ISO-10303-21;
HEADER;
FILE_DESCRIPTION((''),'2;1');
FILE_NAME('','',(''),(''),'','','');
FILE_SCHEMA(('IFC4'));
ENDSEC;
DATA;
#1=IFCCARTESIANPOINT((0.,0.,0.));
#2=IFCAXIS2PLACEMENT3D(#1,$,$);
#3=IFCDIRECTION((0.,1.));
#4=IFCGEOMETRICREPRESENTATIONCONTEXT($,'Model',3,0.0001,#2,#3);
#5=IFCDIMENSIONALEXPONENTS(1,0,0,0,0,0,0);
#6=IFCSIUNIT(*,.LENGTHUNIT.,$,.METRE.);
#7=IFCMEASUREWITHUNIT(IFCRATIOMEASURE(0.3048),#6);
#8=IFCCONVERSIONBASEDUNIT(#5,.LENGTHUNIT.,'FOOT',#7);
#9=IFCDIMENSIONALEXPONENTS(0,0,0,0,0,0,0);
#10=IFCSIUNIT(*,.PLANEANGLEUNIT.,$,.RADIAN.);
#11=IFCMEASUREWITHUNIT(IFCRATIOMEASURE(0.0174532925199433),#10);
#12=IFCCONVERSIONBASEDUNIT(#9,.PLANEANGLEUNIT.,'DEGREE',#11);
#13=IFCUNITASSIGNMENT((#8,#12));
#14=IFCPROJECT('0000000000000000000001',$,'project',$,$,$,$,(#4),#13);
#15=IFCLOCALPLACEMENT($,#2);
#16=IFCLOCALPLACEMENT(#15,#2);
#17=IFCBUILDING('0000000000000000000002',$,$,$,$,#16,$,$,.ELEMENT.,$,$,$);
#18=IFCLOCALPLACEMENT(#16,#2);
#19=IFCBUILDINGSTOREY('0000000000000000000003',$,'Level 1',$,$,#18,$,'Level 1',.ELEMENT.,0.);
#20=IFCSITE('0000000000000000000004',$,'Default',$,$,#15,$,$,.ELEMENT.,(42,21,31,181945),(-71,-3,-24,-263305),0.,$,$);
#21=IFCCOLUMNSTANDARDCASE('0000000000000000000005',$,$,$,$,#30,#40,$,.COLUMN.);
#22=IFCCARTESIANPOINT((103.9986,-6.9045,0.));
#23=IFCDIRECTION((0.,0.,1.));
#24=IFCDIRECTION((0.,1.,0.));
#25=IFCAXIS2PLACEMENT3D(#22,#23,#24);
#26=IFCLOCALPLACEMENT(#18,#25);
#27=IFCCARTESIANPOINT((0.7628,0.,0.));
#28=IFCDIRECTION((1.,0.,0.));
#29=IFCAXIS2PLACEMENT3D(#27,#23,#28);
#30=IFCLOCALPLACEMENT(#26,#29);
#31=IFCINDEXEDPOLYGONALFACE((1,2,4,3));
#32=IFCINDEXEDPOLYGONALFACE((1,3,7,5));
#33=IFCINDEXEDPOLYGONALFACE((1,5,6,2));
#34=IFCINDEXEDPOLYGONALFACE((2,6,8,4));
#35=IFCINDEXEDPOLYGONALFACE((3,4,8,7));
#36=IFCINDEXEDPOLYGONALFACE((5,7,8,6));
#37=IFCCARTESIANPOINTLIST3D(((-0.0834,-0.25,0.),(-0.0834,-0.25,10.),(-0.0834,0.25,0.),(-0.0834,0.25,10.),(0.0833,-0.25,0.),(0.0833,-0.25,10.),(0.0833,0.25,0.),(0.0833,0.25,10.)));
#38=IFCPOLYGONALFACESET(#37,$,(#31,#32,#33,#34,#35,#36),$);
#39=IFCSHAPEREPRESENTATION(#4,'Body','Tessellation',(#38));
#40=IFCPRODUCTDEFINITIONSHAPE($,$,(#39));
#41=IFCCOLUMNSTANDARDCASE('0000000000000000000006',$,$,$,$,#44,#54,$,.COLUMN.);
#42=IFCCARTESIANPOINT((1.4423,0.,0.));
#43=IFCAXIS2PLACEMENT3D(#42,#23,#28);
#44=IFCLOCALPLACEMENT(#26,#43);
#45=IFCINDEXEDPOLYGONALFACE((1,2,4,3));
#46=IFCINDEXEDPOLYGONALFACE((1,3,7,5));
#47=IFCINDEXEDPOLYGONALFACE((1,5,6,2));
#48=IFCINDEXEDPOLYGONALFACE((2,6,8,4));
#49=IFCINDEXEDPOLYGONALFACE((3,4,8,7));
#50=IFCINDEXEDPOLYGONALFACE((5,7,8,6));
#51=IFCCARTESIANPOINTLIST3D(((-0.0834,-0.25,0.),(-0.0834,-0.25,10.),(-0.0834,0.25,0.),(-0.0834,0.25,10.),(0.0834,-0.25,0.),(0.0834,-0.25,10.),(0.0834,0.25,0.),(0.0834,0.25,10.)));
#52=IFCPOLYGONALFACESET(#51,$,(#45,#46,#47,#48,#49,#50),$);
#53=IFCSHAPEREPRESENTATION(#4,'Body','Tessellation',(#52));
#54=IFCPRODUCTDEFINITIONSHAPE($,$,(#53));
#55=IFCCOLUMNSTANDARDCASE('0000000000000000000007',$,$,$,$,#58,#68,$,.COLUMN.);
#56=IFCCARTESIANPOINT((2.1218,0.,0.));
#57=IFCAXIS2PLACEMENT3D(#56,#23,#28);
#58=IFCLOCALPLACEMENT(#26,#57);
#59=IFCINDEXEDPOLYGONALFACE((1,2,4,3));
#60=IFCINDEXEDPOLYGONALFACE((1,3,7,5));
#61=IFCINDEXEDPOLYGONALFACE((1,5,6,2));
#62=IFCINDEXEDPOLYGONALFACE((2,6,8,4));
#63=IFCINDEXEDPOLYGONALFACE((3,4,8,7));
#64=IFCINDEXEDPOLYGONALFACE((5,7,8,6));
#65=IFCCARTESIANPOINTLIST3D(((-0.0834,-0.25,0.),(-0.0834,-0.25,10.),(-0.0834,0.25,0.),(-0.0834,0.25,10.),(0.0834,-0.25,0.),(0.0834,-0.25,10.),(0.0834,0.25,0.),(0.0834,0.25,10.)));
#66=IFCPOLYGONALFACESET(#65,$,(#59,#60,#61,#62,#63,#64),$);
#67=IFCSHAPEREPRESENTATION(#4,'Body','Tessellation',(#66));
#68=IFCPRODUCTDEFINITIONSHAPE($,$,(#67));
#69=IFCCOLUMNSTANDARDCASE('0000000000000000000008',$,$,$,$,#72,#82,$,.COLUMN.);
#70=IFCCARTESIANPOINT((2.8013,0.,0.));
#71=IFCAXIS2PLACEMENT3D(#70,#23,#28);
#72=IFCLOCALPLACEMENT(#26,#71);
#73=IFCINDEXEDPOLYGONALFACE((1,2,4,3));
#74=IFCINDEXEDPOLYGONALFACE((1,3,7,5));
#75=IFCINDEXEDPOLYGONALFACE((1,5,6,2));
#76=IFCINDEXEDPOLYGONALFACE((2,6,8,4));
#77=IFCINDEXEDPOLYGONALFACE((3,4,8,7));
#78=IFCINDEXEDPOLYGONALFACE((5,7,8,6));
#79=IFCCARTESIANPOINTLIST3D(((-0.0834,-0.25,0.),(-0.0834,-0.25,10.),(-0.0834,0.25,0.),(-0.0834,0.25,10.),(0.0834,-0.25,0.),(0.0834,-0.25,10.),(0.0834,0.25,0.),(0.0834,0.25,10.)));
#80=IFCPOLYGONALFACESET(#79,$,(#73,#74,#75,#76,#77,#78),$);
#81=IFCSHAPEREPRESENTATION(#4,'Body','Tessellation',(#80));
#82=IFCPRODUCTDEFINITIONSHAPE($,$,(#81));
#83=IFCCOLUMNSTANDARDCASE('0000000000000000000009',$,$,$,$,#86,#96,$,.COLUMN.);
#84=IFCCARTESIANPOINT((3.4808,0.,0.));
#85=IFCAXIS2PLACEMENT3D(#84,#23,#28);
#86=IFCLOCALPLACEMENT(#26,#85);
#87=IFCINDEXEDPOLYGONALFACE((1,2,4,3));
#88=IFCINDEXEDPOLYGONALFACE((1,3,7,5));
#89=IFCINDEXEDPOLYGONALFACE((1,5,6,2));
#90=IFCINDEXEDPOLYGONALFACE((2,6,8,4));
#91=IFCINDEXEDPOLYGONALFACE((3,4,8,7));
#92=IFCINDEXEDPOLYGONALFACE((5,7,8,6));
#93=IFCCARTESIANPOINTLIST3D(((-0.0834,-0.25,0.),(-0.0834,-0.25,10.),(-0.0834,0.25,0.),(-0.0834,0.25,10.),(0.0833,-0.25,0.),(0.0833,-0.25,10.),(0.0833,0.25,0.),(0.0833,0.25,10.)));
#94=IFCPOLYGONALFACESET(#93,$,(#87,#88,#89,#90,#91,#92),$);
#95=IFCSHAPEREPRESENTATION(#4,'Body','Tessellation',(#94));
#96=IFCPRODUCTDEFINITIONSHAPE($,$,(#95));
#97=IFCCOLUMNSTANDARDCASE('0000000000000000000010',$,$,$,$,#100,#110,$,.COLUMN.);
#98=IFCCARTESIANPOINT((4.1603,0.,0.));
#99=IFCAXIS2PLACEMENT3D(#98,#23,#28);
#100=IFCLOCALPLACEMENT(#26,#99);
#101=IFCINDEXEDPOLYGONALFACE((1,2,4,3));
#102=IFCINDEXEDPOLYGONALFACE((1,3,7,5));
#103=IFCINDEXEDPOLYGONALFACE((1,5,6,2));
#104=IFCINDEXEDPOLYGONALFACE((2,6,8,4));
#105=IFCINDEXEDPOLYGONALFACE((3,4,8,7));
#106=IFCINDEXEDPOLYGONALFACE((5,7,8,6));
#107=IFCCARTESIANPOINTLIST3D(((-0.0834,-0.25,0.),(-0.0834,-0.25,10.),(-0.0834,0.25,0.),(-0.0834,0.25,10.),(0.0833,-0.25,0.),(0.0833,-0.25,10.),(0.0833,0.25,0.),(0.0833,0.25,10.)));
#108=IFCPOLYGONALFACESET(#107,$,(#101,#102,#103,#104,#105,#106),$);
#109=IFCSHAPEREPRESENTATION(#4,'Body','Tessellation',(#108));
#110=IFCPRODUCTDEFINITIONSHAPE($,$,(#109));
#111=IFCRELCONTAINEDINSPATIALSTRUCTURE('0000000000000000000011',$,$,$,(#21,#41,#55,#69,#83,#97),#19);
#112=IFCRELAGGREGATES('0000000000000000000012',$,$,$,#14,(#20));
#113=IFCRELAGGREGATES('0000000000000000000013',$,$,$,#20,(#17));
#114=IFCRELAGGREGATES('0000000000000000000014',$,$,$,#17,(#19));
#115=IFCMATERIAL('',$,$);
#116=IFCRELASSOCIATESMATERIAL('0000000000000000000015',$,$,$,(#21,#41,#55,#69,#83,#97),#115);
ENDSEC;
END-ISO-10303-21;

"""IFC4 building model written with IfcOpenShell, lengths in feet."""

from ifc_helpers import new_model, entity, si_unit, converted_unit, direction, frame, origin, place, context, project, spatial, rectangle, extrude, material, element, save


model = new_model("IFC4")

# Units and contexts
model_context = context("Model", 3, precision=0.0001, world=origin(), true_north=direction((0.0, 1.0)))
ifc_project = project(units=[converted_unit("LENGTHUNIT", "FOOT", entity("IfcRatioMeasure", 0.3048), si_unit("LENGTHUNIT", "METRE"), dimensions=[1, 0, 0, 0, 0, 0, 0]), converted_unit("PLANEANGLEUNIT", "DEGREE", entity("IfcRatioMeasure", 0.0174532925199433), si_unit("PLANEANGLEUNIT", "RADIAN"), dimensions=[0, 0, 0, 0, 0, 0, 0])], contexts=[model_context])

# Site, building, storey
site_placement = place(None, origin())
site = spatial("IfcSite", under=ifc_project, at=site_placement, Name="Default", CompositionType="ELEMENT", RefLatitude=(42, 21, 31, 181945), RefLongitude=(-71, -3, -24, -263305), RefElevation=0.0)
building_placement = place(site_placement, origin())
building = spatial("IfcBuilding", under=site, at=building_placement, CompositionType="ELEMENT")
storey_placement = place(building_placement, origin())
storey = spatial("IfcBuildingStorey", under=building, at=storey_placement, Name="Level 1", LongName="Level 1", CompositionType="ELEMENT", Elevation=0.0)

# Columns
ifc_material_1 = material(Name="")
wall_1_placement = place(storey_placement, frame((103.9986, -6.9045, 0.0), z_axis=(0.0, 0.0, 1.0), x_axis=(0.0, 1.0, 0.0)))
for number, where, z_axis, x_axis in (
    (1, (0.7628, 0.0, 0.0), (0.0, 0.0, 1.0), (1.0, 0.0, 0.0)),
    (2, (1.4423, 0.0, 0.0), (0.0, 0.0, 1.0), (1.0, 0.0, 0.0)),
    (3, (2.1218, 0.0, 0.0), (0.0, 0.0, 1.0), (1.0, 0.0, 0.0)),
    (4, (2.8013, 0.0, 0.0), (0.0, 0.0, 1.0), (1.0, 0.0, 0.0)),
    (5, (3.4808, 0.0, 0.0), (0.0, 0.0, 1.0), (1.0, 0.0, 0.0)),
    (6, (4.1603, 0.0, 0.0), (0.0, 0.0, 1.0), (1.0, 0.0, 0.0)),
):
    element("IfcColumnStandardCase", number, at=place(wall_1_placement, frame(where, z_axis=z_axis, x_axis=x_axis)), inside=storey, material=ifc_material_1, PredefinedType="COLUMN", context=model_context, shape_type="SweptSolid", body=[
        extrude(rectangle(XDim=0.1667, YDim=0.5), origin(), (0.0, 0.0, 1.0), 10.0),
    ])

save(model, "model.ifc")
